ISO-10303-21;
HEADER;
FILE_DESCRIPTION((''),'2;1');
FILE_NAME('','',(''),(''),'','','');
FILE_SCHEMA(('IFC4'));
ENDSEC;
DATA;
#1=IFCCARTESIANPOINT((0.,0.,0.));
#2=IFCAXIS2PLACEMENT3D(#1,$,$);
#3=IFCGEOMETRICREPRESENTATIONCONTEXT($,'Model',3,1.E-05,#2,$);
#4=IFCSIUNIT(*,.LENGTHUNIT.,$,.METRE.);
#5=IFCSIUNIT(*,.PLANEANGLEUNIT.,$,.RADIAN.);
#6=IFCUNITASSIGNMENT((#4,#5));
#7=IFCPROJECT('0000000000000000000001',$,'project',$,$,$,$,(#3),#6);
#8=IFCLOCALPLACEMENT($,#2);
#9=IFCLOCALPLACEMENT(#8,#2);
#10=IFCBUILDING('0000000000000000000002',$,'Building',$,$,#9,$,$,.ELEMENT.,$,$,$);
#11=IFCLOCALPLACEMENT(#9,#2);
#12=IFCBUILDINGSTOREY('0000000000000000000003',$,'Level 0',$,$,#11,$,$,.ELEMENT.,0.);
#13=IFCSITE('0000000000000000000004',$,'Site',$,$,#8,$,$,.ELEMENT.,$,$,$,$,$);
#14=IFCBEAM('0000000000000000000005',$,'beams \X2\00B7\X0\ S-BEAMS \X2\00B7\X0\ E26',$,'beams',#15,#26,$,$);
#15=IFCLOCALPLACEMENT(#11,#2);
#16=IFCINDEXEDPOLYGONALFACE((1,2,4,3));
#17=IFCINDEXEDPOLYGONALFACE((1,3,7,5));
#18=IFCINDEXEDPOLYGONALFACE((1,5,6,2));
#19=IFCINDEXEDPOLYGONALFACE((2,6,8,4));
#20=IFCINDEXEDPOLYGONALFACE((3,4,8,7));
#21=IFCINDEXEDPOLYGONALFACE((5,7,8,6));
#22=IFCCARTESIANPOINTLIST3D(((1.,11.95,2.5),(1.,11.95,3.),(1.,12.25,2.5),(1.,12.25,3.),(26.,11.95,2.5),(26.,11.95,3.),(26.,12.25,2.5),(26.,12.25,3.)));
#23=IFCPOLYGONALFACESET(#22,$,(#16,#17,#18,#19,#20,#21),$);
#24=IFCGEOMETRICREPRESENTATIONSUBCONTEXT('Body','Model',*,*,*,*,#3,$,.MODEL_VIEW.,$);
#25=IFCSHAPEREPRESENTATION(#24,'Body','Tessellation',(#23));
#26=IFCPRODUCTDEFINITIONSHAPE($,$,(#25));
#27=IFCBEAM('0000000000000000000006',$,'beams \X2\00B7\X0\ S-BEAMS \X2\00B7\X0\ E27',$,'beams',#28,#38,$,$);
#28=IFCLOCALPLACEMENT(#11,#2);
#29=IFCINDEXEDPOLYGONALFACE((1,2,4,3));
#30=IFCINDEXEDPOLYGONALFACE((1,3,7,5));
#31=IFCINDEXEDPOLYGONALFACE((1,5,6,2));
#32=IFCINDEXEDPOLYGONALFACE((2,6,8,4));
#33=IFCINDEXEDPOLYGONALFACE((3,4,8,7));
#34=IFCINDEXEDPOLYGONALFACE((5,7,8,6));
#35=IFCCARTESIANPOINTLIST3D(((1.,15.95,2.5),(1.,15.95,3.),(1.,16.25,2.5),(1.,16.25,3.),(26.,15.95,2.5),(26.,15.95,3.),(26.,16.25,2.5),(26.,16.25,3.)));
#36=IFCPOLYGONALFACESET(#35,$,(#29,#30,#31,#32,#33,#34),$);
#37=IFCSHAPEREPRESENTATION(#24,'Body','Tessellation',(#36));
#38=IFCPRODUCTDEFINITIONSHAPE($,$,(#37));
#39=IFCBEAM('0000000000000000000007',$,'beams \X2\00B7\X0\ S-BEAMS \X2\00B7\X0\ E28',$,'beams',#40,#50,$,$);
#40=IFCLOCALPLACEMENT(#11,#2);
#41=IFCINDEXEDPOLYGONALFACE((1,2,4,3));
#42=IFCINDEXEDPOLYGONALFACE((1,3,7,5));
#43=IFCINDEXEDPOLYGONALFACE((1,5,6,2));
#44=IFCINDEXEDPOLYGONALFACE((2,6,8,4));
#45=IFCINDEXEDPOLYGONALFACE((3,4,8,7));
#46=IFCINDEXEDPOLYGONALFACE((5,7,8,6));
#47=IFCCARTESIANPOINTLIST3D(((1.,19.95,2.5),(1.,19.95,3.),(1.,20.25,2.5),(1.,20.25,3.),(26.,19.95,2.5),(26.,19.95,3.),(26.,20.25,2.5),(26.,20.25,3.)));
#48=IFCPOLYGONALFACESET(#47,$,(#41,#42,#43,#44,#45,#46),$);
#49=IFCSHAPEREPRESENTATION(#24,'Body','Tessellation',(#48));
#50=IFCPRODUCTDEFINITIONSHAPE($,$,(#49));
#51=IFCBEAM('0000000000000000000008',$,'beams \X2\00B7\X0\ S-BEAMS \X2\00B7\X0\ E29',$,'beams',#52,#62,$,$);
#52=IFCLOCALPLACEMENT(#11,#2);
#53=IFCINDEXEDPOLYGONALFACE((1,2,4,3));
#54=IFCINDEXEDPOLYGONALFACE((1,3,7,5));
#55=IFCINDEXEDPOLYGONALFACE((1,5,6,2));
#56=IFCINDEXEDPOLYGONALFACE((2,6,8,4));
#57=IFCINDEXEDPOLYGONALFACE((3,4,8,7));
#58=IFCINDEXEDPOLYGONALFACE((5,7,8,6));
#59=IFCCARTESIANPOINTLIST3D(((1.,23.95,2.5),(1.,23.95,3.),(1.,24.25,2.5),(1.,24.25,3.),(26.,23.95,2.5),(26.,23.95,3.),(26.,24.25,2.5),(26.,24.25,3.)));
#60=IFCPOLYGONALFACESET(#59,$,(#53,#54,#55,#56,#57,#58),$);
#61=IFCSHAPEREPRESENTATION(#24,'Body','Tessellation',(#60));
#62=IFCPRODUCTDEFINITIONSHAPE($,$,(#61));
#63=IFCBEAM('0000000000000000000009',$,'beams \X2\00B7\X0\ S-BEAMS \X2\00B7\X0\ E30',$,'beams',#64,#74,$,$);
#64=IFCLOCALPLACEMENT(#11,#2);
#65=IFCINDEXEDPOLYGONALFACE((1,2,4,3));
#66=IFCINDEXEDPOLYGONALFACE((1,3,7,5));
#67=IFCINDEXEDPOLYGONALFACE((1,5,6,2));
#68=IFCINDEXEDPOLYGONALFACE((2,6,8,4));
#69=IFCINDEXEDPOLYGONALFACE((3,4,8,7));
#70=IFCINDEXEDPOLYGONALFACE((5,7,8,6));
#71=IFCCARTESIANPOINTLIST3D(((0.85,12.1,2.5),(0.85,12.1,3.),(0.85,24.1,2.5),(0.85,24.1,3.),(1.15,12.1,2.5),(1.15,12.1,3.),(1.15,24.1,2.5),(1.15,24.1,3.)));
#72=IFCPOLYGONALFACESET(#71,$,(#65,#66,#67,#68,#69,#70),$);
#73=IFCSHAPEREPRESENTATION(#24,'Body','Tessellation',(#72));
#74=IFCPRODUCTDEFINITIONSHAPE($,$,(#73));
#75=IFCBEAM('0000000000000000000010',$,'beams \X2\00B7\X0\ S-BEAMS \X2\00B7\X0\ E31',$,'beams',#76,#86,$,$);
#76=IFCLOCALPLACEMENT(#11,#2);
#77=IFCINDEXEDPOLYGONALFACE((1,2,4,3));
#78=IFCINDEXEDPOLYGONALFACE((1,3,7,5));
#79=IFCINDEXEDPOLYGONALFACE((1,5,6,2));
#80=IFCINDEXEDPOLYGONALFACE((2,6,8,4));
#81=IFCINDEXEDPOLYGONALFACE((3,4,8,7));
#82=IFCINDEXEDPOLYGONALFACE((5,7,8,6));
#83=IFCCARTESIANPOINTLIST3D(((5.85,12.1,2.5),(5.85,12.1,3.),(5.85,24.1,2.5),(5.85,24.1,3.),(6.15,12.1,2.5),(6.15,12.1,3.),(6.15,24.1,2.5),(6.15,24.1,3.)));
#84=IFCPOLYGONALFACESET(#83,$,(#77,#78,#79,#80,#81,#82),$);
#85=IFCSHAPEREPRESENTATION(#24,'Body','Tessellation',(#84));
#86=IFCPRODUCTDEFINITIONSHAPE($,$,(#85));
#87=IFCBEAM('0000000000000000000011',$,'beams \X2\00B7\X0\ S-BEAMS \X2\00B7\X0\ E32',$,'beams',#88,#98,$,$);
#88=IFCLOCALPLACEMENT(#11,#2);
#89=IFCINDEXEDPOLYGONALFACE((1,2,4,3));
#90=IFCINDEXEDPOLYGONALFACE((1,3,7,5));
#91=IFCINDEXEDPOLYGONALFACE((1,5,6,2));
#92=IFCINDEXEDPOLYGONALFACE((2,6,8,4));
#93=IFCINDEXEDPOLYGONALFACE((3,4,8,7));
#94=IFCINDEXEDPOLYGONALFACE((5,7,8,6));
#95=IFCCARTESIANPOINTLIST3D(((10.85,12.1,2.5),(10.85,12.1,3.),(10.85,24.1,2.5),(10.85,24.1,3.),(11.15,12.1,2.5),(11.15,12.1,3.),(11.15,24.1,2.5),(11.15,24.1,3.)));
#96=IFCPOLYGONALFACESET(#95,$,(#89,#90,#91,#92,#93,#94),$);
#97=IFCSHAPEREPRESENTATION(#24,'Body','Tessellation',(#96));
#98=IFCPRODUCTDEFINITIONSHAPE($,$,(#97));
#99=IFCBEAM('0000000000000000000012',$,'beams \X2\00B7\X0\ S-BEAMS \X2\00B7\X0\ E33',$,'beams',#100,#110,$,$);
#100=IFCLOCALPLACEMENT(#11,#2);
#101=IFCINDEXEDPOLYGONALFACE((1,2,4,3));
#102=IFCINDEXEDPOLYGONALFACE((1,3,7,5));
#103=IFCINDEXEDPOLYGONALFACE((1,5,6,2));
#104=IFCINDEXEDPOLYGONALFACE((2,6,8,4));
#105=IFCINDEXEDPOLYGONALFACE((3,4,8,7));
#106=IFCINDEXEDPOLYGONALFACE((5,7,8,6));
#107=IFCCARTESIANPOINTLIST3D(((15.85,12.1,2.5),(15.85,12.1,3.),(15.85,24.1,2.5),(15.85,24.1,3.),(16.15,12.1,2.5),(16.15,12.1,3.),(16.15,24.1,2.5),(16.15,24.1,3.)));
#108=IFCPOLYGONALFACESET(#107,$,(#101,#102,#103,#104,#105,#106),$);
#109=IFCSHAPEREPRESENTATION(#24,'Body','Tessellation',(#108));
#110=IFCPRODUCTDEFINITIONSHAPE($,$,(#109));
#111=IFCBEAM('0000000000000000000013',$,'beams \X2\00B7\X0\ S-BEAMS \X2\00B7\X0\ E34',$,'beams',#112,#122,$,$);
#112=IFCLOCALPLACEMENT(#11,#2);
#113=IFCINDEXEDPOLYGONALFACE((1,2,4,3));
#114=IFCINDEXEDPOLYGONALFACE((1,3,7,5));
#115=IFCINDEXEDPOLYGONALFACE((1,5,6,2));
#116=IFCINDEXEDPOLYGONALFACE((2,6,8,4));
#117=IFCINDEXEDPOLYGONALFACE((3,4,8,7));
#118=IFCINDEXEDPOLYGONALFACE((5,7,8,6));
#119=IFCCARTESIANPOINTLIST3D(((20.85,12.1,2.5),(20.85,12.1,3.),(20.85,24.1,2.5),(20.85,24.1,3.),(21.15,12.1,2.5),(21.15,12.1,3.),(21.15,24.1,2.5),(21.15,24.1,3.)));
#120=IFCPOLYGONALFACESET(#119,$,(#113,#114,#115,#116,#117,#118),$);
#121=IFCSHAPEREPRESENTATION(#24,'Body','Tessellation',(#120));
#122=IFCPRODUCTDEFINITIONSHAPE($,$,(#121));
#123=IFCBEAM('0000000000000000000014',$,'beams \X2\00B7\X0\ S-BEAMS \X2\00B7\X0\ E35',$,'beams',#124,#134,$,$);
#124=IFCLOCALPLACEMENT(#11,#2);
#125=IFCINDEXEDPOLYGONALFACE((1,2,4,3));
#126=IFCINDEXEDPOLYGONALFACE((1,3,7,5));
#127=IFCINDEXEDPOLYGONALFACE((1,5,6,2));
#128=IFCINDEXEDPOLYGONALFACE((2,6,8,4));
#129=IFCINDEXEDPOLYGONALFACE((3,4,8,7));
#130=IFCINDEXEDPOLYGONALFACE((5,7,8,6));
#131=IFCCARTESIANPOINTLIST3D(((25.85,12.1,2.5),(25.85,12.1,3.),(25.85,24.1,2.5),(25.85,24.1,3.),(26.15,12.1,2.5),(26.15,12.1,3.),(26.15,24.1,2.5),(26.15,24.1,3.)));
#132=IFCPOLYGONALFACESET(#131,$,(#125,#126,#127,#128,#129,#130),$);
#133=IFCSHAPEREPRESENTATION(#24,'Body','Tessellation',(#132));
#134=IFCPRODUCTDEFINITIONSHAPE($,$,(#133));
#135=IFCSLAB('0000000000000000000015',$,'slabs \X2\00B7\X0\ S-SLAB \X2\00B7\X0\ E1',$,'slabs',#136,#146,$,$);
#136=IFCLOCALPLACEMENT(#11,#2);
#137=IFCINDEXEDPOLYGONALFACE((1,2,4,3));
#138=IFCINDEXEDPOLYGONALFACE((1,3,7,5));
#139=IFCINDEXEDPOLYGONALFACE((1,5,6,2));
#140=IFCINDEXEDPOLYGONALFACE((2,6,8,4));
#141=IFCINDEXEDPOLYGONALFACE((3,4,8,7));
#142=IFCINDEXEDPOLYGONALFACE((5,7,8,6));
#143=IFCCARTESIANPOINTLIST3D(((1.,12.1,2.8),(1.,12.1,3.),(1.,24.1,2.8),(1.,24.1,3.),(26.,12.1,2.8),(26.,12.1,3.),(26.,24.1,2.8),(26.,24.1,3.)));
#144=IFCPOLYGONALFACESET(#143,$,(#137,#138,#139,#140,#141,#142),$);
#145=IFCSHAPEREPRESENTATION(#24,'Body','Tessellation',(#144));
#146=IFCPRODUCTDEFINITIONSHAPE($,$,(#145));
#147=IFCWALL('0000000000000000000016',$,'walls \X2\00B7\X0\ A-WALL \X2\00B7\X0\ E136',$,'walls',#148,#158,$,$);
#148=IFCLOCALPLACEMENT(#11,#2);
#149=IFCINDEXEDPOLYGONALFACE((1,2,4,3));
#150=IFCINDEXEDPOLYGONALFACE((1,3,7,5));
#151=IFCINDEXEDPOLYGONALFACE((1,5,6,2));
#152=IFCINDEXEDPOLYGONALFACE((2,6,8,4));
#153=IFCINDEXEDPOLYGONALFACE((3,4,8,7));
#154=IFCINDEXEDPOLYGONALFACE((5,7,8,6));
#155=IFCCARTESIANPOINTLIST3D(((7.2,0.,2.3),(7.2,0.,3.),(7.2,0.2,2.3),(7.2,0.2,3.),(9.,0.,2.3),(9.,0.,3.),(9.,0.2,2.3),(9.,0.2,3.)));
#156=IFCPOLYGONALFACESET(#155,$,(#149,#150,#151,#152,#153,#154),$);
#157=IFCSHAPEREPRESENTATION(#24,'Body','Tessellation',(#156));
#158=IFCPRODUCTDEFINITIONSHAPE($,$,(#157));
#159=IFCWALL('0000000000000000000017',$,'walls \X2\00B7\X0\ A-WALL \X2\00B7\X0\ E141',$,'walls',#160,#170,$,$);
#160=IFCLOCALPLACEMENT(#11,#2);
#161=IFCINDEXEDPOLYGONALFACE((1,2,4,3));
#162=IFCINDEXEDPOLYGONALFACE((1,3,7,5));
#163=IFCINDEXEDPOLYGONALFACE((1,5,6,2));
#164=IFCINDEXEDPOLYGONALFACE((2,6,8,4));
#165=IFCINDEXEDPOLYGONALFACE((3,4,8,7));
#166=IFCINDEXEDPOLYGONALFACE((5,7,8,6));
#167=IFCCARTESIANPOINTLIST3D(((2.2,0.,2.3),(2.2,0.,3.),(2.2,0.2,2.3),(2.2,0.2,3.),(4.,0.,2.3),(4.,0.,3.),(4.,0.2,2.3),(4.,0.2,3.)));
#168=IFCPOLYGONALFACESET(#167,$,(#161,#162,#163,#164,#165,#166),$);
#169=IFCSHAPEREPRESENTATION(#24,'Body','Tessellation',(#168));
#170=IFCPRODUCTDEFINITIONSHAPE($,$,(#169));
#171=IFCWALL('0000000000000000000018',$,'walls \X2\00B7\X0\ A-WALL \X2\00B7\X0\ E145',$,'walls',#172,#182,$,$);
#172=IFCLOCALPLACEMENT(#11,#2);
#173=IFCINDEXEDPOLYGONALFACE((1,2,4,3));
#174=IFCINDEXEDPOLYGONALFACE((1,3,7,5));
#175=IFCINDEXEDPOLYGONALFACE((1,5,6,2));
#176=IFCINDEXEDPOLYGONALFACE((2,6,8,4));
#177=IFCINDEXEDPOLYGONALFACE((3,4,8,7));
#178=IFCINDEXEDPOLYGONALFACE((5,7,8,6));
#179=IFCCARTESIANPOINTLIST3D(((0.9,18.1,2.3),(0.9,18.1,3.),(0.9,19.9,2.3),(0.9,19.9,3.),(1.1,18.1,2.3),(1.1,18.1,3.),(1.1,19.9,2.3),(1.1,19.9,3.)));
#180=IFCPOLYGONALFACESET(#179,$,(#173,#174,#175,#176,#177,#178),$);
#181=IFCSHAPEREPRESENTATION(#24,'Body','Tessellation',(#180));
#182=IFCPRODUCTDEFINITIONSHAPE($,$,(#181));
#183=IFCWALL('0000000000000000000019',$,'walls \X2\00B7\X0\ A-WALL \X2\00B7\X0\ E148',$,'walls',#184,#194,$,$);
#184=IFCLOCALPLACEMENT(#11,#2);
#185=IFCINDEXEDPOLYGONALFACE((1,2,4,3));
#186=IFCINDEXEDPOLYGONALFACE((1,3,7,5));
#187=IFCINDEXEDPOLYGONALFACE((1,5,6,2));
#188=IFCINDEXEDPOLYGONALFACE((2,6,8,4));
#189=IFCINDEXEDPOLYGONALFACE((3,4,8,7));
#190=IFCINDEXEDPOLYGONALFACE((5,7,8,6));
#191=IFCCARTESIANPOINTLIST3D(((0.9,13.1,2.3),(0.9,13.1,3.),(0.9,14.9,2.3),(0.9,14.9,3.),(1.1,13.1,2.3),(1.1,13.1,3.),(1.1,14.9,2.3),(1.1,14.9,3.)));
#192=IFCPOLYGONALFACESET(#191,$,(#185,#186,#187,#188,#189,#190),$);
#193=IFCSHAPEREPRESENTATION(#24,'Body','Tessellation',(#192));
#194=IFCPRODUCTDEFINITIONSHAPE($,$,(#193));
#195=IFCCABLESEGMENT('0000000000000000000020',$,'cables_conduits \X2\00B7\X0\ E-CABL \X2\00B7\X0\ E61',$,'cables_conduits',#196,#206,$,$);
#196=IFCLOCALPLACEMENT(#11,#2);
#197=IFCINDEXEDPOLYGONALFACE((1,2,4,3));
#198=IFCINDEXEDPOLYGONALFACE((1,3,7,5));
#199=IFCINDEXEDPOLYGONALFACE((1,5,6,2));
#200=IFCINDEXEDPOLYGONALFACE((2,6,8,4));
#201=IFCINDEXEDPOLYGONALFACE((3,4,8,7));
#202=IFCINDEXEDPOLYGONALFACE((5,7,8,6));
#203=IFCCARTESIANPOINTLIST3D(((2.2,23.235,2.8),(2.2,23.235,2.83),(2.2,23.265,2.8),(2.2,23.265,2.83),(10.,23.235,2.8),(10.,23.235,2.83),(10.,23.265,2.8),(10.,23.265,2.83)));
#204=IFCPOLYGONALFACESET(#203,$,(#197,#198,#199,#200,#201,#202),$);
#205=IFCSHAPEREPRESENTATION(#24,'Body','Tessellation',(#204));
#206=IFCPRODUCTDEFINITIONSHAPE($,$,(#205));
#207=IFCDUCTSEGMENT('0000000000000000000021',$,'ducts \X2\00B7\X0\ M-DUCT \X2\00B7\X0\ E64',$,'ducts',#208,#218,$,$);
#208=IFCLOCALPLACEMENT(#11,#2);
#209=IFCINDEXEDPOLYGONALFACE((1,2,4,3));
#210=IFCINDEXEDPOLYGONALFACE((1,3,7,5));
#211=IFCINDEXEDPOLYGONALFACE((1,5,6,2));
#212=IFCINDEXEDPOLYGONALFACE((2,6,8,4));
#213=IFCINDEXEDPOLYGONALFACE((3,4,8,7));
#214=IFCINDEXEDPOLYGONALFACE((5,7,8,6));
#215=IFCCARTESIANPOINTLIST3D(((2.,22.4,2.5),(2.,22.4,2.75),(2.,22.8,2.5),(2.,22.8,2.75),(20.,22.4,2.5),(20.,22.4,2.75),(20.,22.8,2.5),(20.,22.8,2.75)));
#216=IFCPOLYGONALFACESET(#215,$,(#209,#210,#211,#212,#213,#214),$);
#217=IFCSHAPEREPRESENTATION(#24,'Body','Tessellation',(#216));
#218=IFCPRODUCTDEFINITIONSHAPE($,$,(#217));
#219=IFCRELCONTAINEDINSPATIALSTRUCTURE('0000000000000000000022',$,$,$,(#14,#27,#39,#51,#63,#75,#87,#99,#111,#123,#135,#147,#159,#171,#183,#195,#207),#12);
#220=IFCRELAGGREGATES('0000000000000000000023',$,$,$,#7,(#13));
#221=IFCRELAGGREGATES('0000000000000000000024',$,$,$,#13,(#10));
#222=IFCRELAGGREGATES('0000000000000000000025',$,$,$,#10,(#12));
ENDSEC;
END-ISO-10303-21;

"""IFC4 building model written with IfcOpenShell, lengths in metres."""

from ifc_helpers import new_model, si_unit, frame, origin, place, context, subcontext, project, spatial, polyline, outline, extrude, element, save


model = new_model("IFC4")

# Units and contexts
model_context = context("Model", 3, precision=1e-05, world=origin())
body_context = subcontext(model_context, "Body", "Model", "MODEL_VIEW")
ifc_project = project(units=[si_unit("LENGTHUNIT", "METRE"), si_unit("PLANEANGLEUNIT", "RADIAN")], contexts=[model_context])

# Site, building, storey
site_placement = place(None, origin())
site = spatial("IfcSite", under=ifc_project, at=site_placement, Name="Site", CompositionType="ELEMENT")
building_placement = place(site_placement, origin())
building = spatial("IfcBuilding", under=site, at=building_placement, Name="Building", CompositionType="ELEMENT")
storey_placement = place(building_placement, origin())
storey = spatial("IfcBuildingStorey", under=building, at=storey_placement, Name="Level 0", CompositionType="ELEMENT", Elevation=0.0)

# Beams
beam_1_placement = place(storey_placement, frame((0.0, 0.0, 2.5)))
element("IfcBeam", 1, at=beam_1_placement, inside=storey, Name="beams · S-BEAMS · E26", ObjectType="beams", context=body_context, shape_type="SweptSolid", body=[
    extrude(outline(polyline([(1.0, 11.95), (26.0, 11.95), (26.0, 12.25), (1.0, 12.25), (1.0, 11.95)])), origin(), (0.0, 0.0, 1.0), 0.5),
])
beam_2_placement = place(storey_placement, frame((0.0, 0.0, 2.5)))
element("IfcBeam", 2, at=beam_2_placement, inside=storey, Name="beams · S-BEAMS · E27", ObjectType="beams", context=body_context, shape_type="SweptSolid", body=[
    extrude(outline(polyline([(1.0, 15.95), (26.0, 15.95), (26.0, 16.25), (1.0, 16.25), (1.0, 15.95)])), origin(), (0.0, 0.0, 1.0), 0.5),
])
beam_3_placement = place(storey_placement, frame((0.0, 0.0, 2.5)))
element("IfcBeam", 3, at=beam_3_placement, inside=storey, Name="beams · S-BEAMS · E28", ObjectType="beams", context=body_context, shape_type="SweptSolid", body=[
    extrude(outline(polyline([(1.0, 19.95), (26.0, 19.95), (26.0, 20.25), (1.0, 20.25), (1.0, 19.95)])), origin(), (0.0, 0.0, 1.0), 0.5),
])
beam_4_placement = place(storey_placement, frame((0.0, 0.0, 2.5)))
element("IfcBeam", 4, at=beam_4_placement, inside=storey, Name="beams · S-BEAMS · E29", ObjectType="beams", context=body_context, shape_type="SweptSolid", body=[
    extrude(outline(polyline([(1.0, 23.95), (26.0, 23.95), (26.0, 24.25), (1.0, 24.25), (1.0, 23.95)])), origin(), (0.0, 0.0, 1.0), 0.5),
])
beam_5_placement = place(storey_placement, frame((0.0, 0.0, 2.5)))
element("IfcBeam", 5, at=beam_5_placement, inside=storey, Name="beams · S-BEAMS · E30", ObjectType="beams", context=body_context, shape_type="SweptSolid", body=[
    extrude(outline(polyline([(1.15, 12.1), (1.15, 24.1), (0.85, 24.1), (0.85, 12.1), (1.15, 12.1)])), origin(), (0.0, 0.0, 1.0), 0.5),
])
beam_6_placement = place(storey_placement, frame((0.0, 0.0, 2.5)))
element("IfcBeam", 6, at=beam_6_placement, inside=storey, Name="beams · S-BEAMS · E31", ObjectType="beams", context=body_context, shape_type="SweptSolid", body=[
    extrude(outline(polyline([(6.15, 12.1), (6.15, 24.1), (5.85, 24.1), (5.85, 12.1), (6.15, 12.1)])), origin(), (0.0, 0.0, 1.0), 0.5),
])
beam_7_placement = place(storey_placement, frame((0.0, 0.0, 2.5)))
element("IfcBeam", 7, at=beam_7_placement, inside=storey, Name="beams · S-BEAMS · E32", ObjectType="beams", context=body_context, shape_type="SweptSolid", body=[
    extrude(outline(polyline([(11.15, 12.1), (11.15, 24.1), (10.85, 24.1), (10.85, 12.1), (11.15, 12.1)])), origin(), (0.0, 0.0, 1.0), 0.5),
])
beam_8_placement = place(storey_placement, frame((0.0, 0.0, 2.5)))
element("IfcBeam", 8, at=beam_8_placement, inside=storey, Name="beams · S-BEAMS · E33", ObjectType="beams", context=body_context, shape_type="SweptSolid", body=[
    extrude(outline(polyline([(16.15, 12.1), (16.15, 24.1), (15.85, 24.1), (15.85, 12.1), (16.15, 12.1)])), origin(), (0.0, 0.0, 1.0), 0.5),
])
beam_9_placement = place(storey_placement, frame((0.0, 0.0, 2.5)))
element("IfcBeam", 9, at=beam_9_placement, inside=storey, Name="beams · S-BEAMS · E34", ObjectType="beams", context=body_context, shape_type="SweptSolid", body=[
    extrude(outline(polyline([(21.15, 12.1), (21.15, 24.1), (20.85, 24.1), (20.85, 12.1), (21.15, 12.1)])), origin(), (0.0, 0.0, 1.0), 0.5),
])
beam_10_placement = place(storey_placement, frame((0.0, 0.0, 2.5)))
element("IfcBeam", 10, at=beam_10_placement, inside=storey, Name="beams · S-BEAMS · E35", ObjectType="beams", context=body_context, shape_type="SweptSolid", body=[
    extrude(outline(polyline([(26.15, 12.1), (26.15, 24.1), (25.85, 24.1), (25.85, 12.1), (26.15, 12.1)])), origin(), (0.0, 0.0, 1.0), 0.5),
])

# Slab
slab_placement = place(storey_placement, frame((0.0, 0.0, 2.8)))
element("IfcSlab", 11, at=slab_placement, inside=storey, Name="slabs · S-SLAB · E1", ObjectType="slabs", context=body_context, shape_type="SweptSolid", body=[
    extrude(outline(polyline([(1.0, 12.1), (26.0, 12.1), (26.0, 24.1), (1.0, 24.1), (1.0, 12.1)])), origin(), (0.0, 0.0, 1.0), 0.2),
])

# Walls
wall_1_placement = place(storey_placement, frame((0.0, 0.0, 2.3)))
element("IfcWall", 12, at=wall_1_placement, inside=storey, Name="walls · A-WALL · E136", ObjectType="walls", context=body_context, shape_type="SweptSolid", body=[
    extrude(outline(polyline([(9.0, 0.2), (7.2, 0.2), (7.2, 0.0), (9.0, 0.0), (9.0, 0.2)])), origin(), (0.0, 0.0, 1.0), 0.7),
])
wall_2_placement = place(storey_placement, frame((0.0, 0.0, 2.3)))
element("IfcWall", 13, at=wall_2_placement, inside=storey, Name="walls · A-WALL · E141", ObjectType="walls", context=body_context, shape_type="SweptSolid", body=[
    extrude(outline(polyline([(4.0, 0.2), (2.2, 0.2), (2.2, 0.0), (4.0, 0.0), (4.0, 0.2)])), origin(), (0.0, 0.0, 1.0), 0.7),
])
wall_3_placement = place(storey_placement, frame((0.0, 0.0, 2.3)))
element("IfcWall", 14, at=wall_3_placement, inside=storey, Name="walls · A-WALL · E145", ObjectType="walls", context=body_context, shape_type="SweptSolid", body=[
    extrude(outline(polyline([(0.9, 19.9), (0.9, 18.1), (1.1, 18.1), (1.1, 19.9), (0.9, 19.9)])), origin(), (0.0, 0.0, 1.0), 0.7),
])
wall_4_placement = place(storey_placement, frame((0.0, 0.0, 2.3)))
element("IfcWall", 15, at=wall_4_placement, inside=storey, Name="walls · A-WALL · E148", ObjectType="walls", context=body_context, shape_type="SweptSolid", body=[
    extrude(outline(polyline([(0.9, 14.9), (0.9, 13.1), (1.1, 13.1), (1.1, 14.9), (0.9, 14.9)])), origin(), (0.0, 0.0, 1.0), 0.7),
])

# Cable segment
cable_segment_placement = place(storey_placement, frame((0.0, 0.0, 2.8)))
element("IfcCableSegment", 16, at=cable_segment_placement, inside=storey, Name="cables_conduits · E-CABL · E61", ObjectType="cables_conduits", context=body_context, shape_type="SweptSolid", body=[
    extrude(outline(polyline([(2.2, 23.235), (10.0, 23.235), (10.0, 23.265), (2.2, 23.265), (2.2, 23.235)])), origin(), (0.0, 0.0, 1.0), 0.03),
])

# Duct segment
duct_segment_1_placement = place(storey_placement, frame((0.0, 0.0, 2.5)))
element("IfcDuctSegment", 17, at=duct_segment_1_placement, inside=storey, Name="ducts · M-DUCT · E64", ObjectType="ducts", context=body_context, shape_type="SweptSolid", body=[
    extrude(outline(polyline([(2.0, 22.4), (20.0, 22.4), (20.0, 22.8), (2.0, 22.8), (2.0, 22.4)])), origin(), (0.0, 0.0, 1.0), 0.25),
])

save(model, "model.ifc")
